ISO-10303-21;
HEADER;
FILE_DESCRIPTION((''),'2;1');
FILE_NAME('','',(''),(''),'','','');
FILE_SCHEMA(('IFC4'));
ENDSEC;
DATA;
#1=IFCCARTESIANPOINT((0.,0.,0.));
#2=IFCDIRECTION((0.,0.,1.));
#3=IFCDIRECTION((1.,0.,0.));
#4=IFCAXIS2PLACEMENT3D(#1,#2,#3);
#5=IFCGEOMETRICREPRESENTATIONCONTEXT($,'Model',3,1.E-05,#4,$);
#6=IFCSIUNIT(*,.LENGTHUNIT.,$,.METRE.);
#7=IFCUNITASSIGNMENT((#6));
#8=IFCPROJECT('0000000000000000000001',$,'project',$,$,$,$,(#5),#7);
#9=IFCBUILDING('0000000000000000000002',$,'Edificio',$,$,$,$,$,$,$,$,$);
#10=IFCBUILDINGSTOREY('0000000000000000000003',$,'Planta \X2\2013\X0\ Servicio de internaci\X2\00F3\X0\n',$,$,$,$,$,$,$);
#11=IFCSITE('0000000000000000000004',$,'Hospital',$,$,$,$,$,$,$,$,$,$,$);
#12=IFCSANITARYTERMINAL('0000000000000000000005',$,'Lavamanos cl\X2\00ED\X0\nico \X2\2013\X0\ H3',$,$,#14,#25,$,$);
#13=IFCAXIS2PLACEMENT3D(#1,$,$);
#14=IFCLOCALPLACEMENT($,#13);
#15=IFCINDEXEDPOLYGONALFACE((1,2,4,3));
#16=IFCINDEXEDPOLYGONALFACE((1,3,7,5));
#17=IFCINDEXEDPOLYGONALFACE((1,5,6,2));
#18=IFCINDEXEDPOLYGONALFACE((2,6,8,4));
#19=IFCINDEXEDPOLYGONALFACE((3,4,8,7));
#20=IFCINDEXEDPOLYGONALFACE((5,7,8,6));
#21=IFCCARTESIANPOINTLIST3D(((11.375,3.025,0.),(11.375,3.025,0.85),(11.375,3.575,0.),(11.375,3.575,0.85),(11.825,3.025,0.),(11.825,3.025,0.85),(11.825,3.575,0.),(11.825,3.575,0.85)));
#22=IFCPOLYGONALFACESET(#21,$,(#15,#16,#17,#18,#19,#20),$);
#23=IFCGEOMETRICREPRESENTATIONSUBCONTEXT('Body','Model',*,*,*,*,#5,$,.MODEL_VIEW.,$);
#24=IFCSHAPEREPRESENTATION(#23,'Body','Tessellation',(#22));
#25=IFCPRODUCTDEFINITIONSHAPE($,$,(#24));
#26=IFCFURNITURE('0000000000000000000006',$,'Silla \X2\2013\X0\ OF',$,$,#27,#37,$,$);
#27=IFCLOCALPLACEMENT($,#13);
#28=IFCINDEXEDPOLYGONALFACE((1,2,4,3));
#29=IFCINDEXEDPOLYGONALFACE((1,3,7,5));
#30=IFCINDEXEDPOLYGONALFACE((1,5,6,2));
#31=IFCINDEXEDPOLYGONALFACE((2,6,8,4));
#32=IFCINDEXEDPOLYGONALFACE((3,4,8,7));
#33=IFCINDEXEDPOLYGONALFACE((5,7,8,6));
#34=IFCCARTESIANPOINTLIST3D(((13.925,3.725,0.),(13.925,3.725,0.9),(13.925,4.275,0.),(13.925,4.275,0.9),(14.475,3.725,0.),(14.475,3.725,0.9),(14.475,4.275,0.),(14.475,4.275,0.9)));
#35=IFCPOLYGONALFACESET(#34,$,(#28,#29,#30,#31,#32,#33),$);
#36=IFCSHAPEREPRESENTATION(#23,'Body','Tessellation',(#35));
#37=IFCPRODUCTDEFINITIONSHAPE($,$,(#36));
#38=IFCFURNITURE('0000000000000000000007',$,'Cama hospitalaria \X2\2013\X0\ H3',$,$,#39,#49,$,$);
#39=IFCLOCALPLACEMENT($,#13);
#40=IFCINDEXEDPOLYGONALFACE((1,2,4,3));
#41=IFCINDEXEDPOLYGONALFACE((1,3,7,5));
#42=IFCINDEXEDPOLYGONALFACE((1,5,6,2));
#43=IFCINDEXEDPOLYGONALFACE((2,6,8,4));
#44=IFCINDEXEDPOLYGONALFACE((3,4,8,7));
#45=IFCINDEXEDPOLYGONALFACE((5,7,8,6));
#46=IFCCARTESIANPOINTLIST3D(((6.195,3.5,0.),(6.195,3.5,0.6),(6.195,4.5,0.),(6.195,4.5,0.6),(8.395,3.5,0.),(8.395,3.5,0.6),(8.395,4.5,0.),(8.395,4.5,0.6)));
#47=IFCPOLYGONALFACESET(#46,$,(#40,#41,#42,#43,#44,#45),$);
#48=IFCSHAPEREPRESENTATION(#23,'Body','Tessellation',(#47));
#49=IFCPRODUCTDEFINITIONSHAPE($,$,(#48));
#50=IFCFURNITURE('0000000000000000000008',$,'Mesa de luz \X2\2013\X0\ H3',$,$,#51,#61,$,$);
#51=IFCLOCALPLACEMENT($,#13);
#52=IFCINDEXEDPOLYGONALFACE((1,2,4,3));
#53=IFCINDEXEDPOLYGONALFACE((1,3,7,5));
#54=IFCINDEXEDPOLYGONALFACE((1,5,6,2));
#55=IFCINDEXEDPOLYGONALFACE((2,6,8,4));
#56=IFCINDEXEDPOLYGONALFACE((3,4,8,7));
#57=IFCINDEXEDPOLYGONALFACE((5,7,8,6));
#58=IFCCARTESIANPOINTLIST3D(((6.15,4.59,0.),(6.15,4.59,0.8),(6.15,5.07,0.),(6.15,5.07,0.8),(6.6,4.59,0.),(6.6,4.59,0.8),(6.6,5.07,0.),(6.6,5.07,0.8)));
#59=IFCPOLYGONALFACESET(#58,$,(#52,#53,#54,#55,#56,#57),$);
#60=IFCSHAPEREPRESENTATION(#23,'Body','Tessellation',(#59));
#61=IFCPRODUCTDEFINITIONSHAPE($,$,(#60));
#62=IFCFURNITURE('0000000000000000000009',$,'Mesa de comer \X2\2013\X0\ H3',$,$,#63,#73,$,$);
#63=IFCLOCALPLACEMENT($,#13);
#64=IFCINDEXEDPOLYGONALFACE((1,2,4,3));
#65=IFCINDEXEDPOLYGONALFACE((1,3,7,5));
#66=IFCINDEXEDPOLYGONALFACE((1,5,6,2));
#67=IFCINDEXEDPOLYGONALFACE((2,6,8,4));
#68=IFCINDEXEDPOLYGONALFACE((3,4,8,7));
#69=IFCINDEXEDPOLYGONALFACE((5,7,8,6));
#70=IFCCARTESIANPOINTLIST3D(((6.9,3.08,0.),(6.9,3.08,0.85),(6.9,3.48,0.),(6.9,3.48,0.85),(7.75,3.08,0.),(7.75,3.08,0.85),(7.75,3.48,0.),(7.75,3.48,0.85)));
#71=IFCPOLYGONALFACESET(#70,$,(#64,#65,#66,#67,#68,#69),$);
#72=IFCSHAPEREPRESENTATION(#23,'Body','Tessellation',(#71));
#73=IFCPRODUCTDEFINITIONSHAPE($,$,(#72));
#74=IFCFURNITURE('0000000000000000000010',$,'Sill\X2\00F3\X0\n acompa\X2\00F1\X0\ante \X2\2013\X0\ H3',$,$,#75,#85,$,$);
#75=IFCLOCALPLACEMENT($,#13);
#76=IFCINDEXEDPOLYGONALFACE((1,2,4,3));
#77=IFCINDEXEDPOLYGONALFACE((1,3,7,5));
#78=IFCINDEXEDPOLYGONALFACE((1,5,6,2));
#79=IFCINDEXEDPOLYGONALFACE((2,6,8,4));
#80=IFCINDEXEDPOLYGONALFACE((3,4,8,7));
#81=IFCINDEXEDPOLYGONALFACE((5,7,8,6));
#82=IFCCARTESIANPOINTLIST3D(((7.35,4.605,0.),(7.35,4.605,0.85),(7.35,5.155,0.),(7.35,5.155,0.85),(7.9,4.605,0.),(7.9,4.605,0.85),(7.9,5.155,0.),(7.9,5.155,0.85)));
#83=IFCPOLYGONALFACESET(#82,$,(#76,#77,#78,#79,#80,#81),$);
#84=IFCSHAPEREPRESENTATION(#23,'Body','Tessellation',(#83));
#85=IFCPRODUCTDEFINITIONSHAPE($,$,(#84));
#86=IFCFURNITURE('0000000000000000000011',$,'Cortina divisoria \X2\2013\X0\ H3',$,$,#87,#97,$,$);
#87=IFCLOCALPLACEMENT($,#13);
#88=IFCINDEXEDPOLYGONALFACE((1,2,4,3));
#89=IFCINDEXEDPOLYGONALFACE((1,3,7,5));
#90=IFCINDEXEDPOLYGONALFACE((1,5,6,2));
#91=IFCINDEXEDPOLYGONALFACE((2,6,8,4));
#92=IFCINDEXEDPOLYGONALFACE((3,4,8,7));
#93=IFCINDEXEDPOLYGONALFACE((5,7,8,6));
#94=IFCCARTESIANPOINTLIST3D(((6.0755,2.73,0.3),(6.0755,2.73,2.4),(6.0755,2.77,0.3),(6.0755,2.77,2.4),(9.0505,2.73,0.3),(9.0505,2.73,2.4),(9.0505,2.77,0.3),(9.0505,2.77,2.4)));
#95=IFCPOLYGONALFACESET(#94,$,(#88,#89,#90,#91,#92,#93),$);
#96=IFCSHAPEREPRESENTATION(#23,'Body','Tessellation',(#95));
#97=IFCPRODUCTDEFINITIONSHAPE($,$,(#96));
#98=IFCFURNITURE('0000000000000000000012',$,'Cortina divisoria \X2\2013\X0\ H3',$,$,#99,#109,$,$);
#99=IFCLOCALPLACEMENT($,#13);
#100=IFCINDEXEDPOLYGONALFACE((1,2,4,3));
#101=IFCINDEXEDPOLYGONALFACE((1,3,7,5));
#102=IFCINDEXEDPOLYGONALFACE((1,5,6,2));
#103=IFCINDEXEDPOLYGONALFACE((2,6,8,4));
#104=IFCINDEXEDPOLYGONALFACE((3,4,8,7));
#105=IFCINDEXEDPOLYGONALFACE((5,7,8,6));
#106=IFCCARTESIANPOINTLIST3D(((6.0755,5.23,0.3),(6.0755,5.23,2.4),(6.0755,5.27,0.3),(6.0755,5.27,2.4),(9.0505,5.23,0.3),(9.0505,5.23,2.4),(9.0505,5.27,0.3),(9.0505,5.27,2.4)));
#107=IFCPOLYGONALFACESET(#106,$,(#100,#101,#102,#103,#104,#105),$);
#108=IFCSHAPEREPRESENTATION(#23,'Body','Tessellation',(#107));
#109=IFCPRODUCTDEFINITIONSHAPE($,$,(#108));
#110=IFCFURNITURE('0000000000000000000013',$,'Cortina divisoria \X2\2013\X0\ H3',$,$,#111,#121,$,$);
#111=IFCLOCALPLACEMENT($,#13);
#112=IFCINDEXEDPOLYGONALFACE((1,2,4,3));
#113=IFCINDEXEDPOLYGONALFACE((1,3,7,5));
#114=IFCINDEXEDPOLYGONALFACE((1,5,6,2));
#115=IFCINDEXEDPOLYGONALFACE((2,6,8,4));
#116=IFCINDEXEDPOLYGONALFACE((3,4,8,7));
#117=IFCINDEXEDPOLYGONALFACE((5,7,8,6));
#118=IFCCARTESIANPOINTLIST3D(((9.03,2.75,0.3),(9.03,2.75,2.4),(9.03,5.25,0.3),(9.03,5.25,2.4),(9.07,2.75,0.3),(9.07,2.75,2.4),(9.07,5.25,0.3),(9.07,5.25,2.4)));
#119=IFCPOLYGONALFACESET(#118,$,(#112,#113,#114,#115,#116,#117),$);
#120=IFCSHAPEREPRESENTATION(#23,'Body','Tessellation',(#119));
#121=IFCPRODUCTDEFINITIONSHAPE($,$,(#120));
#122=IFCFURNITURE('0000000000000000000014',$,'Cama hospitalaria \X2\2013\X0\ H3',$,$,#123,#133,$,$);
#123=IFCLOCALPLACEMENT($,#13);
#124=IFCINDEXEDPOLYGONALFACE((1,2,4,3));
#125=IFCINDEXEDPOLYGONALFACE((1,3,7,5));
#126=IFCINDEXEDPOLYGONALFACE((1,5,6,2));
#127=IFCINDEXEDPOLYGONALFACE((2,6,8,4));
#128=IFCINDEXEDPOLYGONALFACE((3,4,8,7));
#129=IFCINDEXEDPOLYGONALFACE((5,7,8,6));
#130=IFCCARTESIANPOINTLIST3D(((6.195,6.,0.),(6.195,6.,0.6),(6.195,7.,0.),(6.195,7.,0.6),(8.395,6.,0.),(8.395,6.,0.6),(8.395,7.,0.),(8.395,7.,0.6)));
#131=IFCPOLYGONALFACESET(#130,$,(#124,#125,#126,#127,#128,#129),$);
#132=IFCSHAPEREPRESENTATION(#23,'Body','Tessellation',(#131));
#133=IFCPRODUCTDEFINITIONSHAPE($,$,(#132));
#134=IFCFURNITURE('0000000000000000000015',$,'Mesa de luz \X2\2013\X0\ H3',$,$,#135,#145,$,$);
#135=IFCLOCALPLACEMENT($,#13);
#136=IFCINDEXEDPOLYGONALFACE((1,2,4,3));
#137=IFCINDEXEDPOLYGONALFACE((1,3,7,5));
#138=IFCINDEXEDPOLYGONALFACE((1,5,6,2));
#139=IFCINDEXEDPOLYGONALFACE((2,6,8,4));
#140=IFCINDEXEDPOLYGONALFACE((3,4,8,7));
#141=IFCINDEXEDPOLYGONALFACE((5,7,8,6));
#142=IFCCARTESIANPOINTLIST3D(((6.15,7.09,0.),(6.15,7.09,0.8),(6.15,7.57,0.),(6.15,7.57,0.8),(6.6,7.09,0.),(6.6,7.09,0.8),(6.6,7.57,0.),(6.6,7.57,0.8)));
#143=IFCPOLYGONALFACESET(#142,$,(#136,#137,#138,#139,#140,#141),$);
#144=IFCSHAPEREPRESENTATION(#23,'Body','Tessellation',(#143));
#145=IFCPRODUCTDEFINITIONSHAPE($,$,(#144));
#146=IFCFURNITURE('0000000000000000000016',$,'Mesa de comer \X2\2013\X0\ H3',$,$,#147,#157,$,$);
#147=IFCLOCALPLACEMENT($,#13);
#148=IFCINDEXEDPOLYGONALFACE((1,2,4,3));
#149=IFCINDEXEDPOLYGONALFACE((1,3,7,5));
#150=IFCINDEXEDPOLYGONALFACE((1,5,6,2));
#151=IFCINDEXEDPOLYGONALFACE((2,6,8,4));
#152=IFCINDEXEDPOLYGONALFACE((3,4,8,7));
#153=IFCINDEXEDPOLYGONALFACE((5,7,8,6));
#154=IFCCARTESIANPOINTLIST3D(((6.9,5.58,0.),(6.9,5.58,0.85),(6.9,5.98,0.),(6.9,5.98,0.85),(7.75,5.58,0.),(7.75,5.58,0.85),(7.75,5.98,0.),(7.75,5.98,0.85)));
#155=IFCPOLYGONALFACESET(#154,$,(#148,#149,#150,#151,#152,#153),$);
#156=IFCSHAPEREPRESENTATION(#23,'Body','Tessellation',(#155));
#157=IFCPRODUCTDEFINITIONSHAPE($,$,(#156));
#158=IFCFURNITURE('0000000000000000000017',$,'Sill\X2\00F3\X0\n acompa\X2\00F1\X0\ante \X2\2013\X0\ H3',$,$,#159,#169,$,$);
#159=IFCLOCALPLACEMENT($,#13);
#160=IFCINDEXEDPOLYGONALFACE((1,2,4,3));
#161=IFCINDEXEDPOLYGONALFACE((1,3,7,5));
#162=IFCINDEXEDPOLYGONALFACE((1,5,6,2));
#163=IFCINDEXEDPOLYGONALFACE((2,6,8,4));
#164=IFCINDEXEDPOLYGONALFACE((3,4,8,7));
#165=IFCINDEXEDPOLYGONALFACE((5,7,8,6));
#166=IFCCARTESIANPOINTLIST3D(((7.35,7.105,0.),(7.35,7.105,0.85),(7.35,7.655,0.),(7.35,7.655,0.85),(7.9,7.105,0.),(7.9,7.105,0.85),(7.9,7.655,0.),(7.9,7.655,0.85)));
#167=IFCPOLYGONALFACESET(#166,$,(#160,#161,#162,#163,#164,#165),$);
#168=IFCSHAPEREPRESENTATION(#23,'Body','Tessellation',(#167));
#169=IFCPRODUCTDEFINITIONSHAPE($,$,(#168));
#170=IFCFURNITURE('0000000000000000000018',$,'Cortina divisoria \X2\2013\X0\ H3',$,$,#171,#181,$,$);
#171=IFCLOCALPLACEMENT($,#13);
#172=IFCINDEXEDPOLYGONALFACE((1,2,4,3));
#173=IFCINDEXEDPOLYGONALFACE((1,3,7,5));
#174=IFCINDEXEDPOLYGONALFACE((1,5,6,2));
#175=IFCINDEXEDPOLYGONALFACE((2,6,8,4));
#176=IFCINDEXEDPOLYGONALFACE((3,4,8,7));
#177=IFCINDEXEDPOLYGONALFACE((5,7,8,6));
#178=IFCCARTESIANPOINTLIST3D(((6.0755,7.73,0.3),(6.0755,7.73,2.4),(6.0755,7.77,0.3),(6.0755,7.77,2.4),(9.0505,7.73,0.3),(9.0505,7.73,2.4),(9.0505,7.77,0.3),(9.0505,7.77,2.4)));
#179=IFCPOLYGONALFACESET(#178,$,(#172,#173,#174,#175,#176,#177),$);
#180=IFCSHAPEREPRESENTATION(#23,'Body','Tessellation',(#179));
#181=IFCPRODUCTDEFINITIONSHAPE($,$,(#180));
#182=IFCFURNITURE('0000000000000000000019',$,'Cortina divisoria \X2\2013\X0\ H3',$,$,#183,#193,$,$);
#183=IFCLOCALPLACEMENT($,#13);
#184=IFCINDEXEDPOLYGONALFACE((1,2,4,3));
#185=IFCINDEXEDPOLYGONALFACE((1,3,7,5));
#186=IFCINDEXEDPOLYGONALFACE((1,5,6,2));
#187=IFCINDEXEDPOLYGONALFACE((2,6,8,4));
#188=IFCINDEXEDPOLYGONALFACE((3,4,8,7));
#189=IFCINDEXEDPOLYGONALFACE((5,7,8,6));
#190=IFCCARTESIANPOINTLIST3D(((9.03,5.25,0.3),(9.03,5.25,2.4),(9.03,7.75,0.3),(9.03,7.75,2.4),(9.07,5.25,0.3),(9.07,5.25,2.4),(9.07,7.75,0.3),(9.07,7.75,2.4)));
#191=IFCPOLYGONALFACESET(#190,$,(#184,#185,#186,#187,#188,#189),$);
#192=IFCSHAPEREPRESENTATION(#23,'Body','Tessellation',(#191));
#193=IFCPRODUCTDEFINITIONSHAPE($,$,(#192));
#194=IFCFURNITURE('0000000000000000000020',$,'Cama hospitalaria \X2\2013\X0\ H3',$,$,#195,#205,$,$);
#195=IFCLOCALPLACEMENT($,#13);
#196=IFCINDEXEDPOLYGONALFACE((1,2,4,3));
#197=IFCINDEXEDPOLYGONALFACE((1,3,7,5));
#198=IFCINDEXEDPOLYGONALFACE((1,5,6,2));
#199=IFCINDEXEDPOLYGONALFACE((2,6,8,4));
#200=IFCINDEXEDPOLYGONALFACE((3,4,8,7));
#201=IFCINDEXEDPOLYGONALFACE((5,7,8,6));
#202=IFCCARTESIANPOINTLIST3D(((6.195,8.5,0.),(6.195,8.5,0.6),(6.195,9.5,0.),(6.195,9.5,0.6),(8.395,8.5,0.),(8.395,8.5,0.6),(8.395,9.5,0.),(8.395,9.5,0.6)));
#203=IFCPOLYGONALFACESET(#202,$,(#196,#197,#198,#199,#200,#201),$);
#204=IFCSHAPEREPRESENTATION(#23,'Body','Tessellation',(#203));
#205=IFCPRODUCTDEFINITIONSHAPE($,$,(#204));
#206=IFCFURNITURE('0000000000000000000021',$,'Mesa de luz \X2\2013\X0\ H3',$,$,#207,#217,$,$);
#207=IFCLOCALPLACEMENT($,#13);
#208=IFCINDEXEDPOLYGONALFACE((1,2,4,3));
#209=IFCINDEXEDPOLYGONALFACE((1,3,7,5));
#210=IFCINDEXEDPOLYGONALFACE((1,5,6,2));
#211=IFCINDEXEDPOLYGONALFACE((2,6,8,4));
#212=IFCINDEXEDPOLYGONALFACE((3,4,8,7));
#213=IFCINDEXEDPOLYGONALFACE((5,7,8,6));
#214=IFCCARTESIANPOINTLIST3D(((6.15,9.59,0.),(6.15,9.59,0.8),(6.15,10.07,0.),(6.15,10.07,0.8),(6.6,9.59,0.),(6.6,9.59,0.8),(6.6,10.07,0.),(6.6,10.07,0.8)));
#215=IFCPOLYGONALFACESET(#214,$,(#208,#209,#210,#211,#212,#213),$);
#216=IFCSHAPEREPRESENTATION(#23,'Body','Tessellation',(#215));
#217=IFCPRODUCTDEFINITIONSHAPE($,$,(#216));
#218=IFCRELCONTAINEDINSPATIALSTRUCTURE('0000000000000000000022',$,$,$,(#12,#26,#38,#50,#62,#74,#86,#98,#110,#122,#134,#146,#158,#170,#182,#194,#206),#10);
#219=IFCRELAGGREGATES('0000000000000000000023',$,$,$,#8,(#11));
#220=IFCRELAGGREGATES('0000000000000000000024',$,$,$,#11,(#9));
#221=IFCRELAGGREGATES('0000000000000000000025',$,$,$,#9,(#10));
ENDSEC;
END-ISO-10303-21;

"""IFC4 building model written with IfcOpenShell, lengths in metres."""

from ifc_helpers import new_model, si_unit, frame, origin_with_axes, context, subcontext, project, spatial, line, indexed_curve, outline, extrude, element, save


model = new_model("IFC4")

# Units and contexts
model_context = context("Model", 3, precision=1e-05, world=origin_with_axes())
body_context = subcontext(model_context, "Body", "Model", "MODEL_VIEW")
ifc_project = project(units=[si_unit("LENGTHUNIT", "METRE")], contexts=[model_context])

# Site, building, storey
site = spatial("IfcSite", under=ifc_project, Name="Hospital")
building = spatial("IfcBuilding", under=site, Name="Edificio")
storey = spatial("IfcBuildingStorey", under=building, Name="Planta – Servicio de internación")

# Sanitary terminal
element("IfcSanitaryTerminal", 1, inside=storey, Name="Lavamanos clínico – H3", context=body_context, shape_type="SweptSolid", body=[
    extrude(outline(indexed_curve([(0.0, 0.0), (0.45, 0.0), (0.45, 0.55), (0.0, 0.55)], segments=[line(1, 2, 3, 4, 1)])), frame((11.375, 3.025, 0.0), z_axis=(0.0, 0.0, 1.0), x_axis=(1.0, 0.0, 0.0)), (0.0, 0.0, 1.0), 0.85),
])

# Furniture
element("IfcFurniture", 2, inside=storey, Name="Silla – OF", context=body_context, shape_type="SweptSolid", body=[
    extrude(outline(indexed_curve([(0.0, 0.0), (0.55, 0.0), (0.55, 0.55), (0.0, 0.55)], segments=[line(1, 2, 3, 4, 1)])), frame((13.925, 3.725, 0.0), z_axis=(0.0, 0.0, 1.0), x_axis=(1.0, 0.0, 0.0)), (0.0, 0.0, 1.0), 0.9),
])
element("IfcFurniture", 3, inside=storey, Name="Cama hospitalaria – H3", context=body_context, shape_type="SweptSolid", body=[
    extrude(outline(indexed_curve([(0.0, 0.0), (2.2, 0.0), (2.2, 1.0), (0.0, 1.0)], segments=[line(1, 2, 3, 4, 1)])), frame((6.195, 3.5, 0.0), z_axis=(0.0, 0.0, 1.0), x_axis=(1.0, 0.0, 0.0)), (0.0, 0.0, 1.0), 0.6),
])
element("IfcFurniture", 4, inside=storey, Name="Mesa de luz – H3", context=body_context, shape_type="SweptSolid", body=[
    extrude(outline(indexed_curve([(0.0, 0.0), (0.45, 0.0), (0.45, 0.48), (0.0, 0.48)], segments=[line(1, 2, 3, 4, 1)])), frame((6.15, 4.59, 0.0), z_axis=(0.0, 0.0, 1.0), x_axis=(1.0, 0.0, 0.0)), (0.0, 0.0, 1.0), 0.8),
])
element("IfcFurniture", 5, inside=storey, Name="Mesa de comer – H3", context=body_context, shape_type="SweptSolid", body=[
    extrude(outline(indexed_curve([(0.0, 0.0), (0.85, 0.0), (0.85, 0.4), (0.0, 0.4)], segments=[line(1, 2, 3, 4, 1)])), frame((6.9, 3.08, 0.0), z_axis=(0.0, 0.0, 1.0), x_axis=(1.0, 0.0, 0.0)), (0.0, 0.0, 1.0), 0.85),
])
element("IfcFurniture", 6, inside=storey, Name="Sillón acompañante – H3", context=body_context, shape_type="SweptSolid", body=[
    extrude(outline(indexed_curve([(0.0, 0.0), (0.55, 0.0), (0.55, 0.55), (0.0, 0.55)], segments=[line(1, 2, 3, 4, 1)])), frame((7.35, 4.605, 0.0), z_axis=(0.0, 0.0, 1.0), x_axis=(1.0, 0.0, 0.0)), (0.0, 0.0, 1.0), 0.85),
])
element("IfcFurniture", 7, inside=storey, Name="Cortina divisoria – H3", context=body_context, shape_type="SweptSolid", body=[
    extrude(outline(indexed_curve([(0.0, 0.0), (2.975, 0.0), (2.975, 0.04), (0.0, 0.04)], segments=[line(1, 2, 3, 4, 1)])), frame((6.0755, 2.73, 0.3), z_axis=(0.0, 0.0, 1.0), x_axis=(1.0, 0.0, 0.0)), (0.0, 0.0, 1.0), 2.1),
])
element("IfcFurniture", 8, inside=storey, Name="Cortina divisoria – H3", context=body_context, shape_type="SweptSolid", body=[
    extrude(outline(indexed_curve([(0.0, 0.0), (2.975, 0.0), (2.975, 0.04), (0.0, 0.04)], segments=[line(1, 2, 3, 4, 1)])), frame((6.0755, 5.23, 0.3), z_axis=(0.0, 0.0, 1.0), x_axis=(1.0, 0.0, 0.0)), (0.0, 0.0, 1.0), 2.1),
])
element("IfcFurniture", 9, inside=storey, Name="Cortina divisoria – H3", context=body_context, shape_type="SweptSolid", body=[
    extrude(outline(indexed_curve([(0.0, 0.0), (0.04, 0.0), (0.04, 2.5), (0.0, 2.5)], segments=[line(1, 2, 3, 4, 1)])), frame((9.03, 2.75, 0.3), z_axis=(0.0, 0.0, 1.0), x_axis=(1.0, 0.0, 0.0)), (0.0, 0.0, 1.0), 2.1),
])
element("IfcFurniture", 10, inside=storey, Name="Cama hospitalaria – H3", context=body_context, shape_type="SweptSolid", body=[
    extrude(outline(indexed_curve([(0.0, 0.0), (2.2, 0.0), (2.2, 1.0), (0.0, 1.0)], segments=[line(1, 2, 3, 4, 1)])), frame((6.195, 6.0, 0.0), z_axis=(0.0, 0.0, 1.0), x_axis=(1.0, 0.0, 0.0)), (0.0, 0.0, 1.0), 0.6),
])
element("IfcFurniture", 11, inside=storey, Name="Mesa de luz – H3", context=body_context, shape_type="SweptSolid", body=[
    extrude(outline(indexed_curve([(0.0, 0.0), (0.45, 0.0), (0.45, 0.48), (0.0, 0.48)], segments=[line(1, 2, 3, 4, 1)])), frame((6.15, 7.09, 0.0), z_axis=(0.0, 0.0, 1.0), x_axis=(1.0, 0.0, 0.0)), (0.0, 0.0, 1.0), 0.8),
])
element("IfcFurniture", 12, inside=storey, Name="Mesa de comer – H3", context=body_context, shape_type="SweptSolid", body=[
    extrude(outline(indexed_curve([(0.0, 0.0), (0.85, 0.0), (0.85, 0.4), (0.0, 0.4)], segments=[line(1, 2, 3, 4, 1)])), frame((6.9, 5.58, 0.0), z_axis=(0.0, 0.0, 1.0), x_axis=(1.0, 0.0, 0.0)), (0.0, 0.0, 1.0), 0.85),
])
element("IfcFurniture", 13, inside=storey, Name="Sillón acompañante – H3", context=body_context, shape_type="SweptSolid", body=[
    extrude(outline(indexed_curve([(0.0, 0.0), (0.55, 0.0), (0.55, 0.55), (0.0, 0.55)], segments=[line(1, 2, 3, 4, 1)])), frame((7.35, 7.105, 0.0), z_axis=(0.0, 0.0, 1.0), x_axis=(1.0, 0.0, 0.0)), (0.0, 0.0, 1.0), 0.85),
])
element("IfcFurniture", 14, inside=storey, Name="Cortina divisoria – H3", context=body_context, shape_type="SweptSolid", body=[
    extrude(outline(indexed_curve([(0.0, 0.0), (2.975, 0.0), (2.975, 0.04), (0.0, 0.04)], segments=[line(1, 2, 3, 4, 1)])), frame((6.0755, 7.73, 0.3), z_axis=(0.0, 0.0, 1.0), x_axis=(1.0, 0.0, 0.0)), (0.0, 0.0, 1.0), 2.1),
])
element("IfcFurniture", 15, inside=storey, Name="Cortina divisoria – H3", context=body_context, shape_type="SweptSolid", body=[
    extrude(outline(indexed_curve([(0.0, 0.0), (0.04, 0.0), (0.04, 2.5), (0.0, 2.5)], segments=[line(1, 2, 3, 4, 1)])), frame((9.03, 5.25, 0.3), z_axis=(0.0, 0.0, 1.0), x_axis=(1.0, 0.0, 0.0)), (0.0, 0.0, 1.0), 2.1),
])
element("IfcFurniture", 16, inside=storey, Name="Cama hospitalaria – H3", context=body_context, shape_type="SweptSolid", body=[
    extrude(outline(indexed_curve([(0.0, 0.0), (2.2, 0.0), (2.2, 1.0), (0.0, 1.0)], segments=[line(1, 2, 3, 4, 1)])), frame((6.195, 8.5, 0.0), z_axis=(0.0, 0.0, 1.0), x_axis=(1.0, 0.0, 0.0)), (0.0, 0.0, 1.0), 0.6),
])
element("IfcFurniture", 17, inside=storey, Name="Mesa de luz – H3", context=body_context, shape_type="SweptSolid", body=[
    extrude(outline(indexed_curve([(0.0, 0.0), (0.45, 0.0), (0.45, 0.48), (0.0, 0.48)], segments=[line(1, 2, 3, 4, 1)])), frame((6.15, 9.59, 0.0), z_axis=(0.0, 0.0, 1.0), x_axis=(1.0, 0.0, 0.0)), (0.0, 0.0, 1.0), 0.8),
])

save(model, "model.ifc")
